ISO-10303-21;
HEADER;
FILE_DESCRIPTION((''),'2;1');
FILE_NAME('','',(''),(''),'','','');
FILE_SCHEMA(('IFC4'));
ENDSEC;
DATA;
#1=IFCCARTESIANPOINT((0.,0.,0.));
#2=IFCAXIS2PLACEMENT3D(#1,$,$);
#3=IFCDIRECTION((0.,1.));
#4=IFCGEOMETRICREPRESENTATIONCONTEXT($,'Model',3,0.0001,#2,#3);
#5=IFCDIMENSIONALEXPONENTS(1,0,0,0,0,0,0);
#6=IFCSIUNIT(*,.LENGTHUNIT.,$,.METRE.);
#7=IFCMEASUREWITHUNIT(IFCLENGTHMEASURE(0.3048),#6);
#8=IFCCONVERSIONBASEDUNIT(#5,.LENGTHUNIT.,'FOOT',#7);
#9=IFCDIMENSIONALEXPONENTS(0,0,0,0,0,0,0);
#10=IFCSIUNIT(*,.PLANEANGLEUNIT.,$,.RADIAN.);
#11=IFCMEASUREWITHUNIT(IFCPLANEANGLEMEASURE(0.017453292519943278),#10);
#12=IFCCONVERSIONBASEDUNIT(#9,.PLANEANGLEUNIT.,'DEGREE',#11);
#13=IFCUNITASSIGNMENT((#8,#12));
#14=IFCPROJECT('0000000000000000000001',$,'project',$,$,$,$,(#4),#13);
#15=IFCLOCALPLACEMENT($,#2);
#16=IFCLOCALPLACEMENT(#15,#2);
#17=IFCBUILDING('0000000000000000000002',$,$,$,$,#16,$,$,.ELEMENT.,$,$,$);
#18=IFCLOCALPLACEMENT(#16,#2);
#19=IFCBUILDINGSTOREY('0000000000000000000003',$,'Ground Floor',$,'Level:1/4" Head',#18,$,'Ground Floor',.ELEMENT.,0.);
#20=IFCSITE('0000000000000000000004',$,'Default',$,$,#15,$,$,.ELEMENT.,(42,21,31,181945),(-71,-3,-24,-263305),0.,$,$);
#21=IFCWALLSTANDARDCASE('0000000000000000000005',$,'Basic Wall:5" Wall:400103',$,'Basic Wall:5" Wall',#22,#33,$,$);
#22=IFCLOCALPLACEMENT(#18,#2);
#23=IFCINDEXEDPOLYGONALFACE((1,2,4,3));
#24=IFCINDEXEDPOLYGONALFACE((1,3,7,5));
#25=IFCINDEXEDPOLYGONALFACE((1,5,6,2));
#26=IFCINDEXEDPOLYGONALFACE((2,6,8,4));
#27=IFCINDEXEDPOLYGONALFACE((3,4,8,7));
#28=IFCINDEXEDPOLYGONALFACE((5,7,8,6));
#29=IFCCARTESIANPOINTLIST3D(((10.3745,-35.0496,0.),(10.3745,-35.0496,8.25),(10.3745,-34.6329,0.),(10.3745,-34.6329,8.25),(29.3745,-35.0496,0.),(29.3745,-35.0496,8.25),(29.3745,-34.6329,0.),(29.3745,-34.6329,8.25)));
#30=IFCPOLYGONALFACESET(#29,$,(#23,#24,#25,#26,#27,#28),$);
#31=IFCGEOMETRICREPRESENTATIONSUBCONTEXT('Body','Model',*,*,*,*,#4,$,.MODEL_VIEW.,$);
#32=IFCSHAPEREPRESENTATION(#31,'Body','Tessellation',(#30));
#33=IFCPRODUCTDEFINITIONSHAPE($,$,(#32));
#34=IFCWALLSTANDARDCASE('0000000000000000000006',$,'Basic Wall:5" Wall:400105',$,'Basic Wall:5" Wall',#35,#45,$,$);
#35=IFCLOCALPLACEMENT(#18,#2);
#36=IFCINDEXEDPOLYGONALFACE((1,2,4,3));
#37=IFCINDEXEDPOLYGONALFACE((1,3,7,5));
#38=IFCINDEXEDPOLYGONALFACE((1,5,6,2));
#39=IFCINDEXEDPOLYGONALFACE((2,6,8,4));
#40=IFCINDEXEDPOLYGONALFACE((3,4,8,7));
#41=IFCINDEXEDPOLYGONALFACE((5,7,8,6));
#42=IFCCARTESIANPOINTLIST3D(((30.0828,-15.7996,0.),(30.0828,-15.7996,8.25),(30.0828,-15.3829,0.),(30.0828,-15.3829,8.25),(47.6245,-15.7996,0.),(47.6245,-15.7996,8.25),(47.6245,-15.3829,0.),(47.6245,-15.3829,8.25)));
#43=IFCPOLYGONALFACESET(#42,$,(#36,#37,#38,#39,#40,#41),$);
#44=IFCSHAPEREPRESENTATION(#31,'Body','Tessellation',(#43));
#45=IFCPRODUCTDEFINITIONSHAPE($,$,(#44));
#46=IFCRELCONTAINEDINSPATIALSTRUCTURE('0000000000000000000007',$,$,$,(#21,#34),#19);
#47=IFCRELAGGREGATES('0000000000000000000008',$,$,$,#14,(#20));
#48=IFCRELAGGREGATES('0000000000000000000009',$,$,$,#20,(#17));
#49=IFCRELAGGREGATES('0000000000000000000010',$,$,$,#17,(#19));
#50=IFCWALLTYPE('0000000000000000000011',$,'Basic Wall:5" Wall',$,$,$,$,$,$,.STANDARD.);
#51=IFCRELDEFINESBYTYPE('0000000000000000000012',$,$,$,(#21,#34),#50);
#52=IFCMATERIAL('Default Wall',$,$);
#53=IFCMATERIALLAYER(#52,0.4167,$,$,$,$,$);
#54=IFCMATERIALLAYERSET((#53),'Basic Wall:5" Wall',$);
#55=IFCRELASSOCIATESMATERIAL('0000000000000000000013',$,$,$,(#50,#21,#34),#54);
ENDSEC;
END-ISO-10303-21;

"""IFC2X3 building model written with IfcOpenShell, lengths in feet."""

from ifc_helpers import new_model, entity, si_unit, converted_unit, direction, frame, frame_2d, origin, place, context, subcontext, project, spatial, rectangle, extrude, material, layer, layer_set, layer_usage, type_object, element, save


model = new_model("IFC2X3")

# Units and contexts
model_context = context("Model", 3, precision=0.0001, world=origin(), true_north=direction((0.0, 1.0)))
body_context = subcontext(model_context, "Body", "Model", "MODEL_VIEW")
ifc_project = project(units=[converted_unit("LENGTHUNIT", "FOOT", entity("IfcLengthMeasure", 0.3048), si_unit("LENGTHUNIT", "METRE"), dimensions=[1, 0, 0, 0, 0, 0, 0]), converted_unit("PLANEANGLEUNIT", "DEGREE", entity("IfcPlaneAngleMeasure", 0.017453292519943278), si_unit("PLANEANGLEUNIT", "RADIAN"), dimensions=[0, 0, 0, 0, 0, 0, 0])], contexts=[model_context])

# Site, building, storey
site_placement = place(None, origin())
site = spatial("IfcSite", under=ifc_project, at=site_placement, Name="Default", CompositionType="ELEMENT", RefLatitude=(42, 21, 31, 181945), RefLongitude=(-71, -3, -24, -263305), RefElevation=0.0)
building_placement = place(site_placement, origin())
building = spatial("IfcBuilding", under=site, at=building_placement, CompositionType="ELEMENT")
storey_placement = place(building_placement, origin())
storey = spatial("IfcBuildingStorey", under=building, at=storey_placement, Name="Ground Floor", ObjectType="Level:1/4\" Head", LongName="Ground Floor", CompositionType="ELEMENT", Elevation=0.0)

# Shared definitions
ifc_material_1 = material(Name="Default Wall")

# Wall
ifc_layer_1 = layer(ifc_material_1, 0.4167)
ifc_layer_set_1 = layer_set([ifc_layer_1], Name="Basic Wall:5\" Wall")
ifc_layer_usage_1 = layer_usage(ifc_layer_set_1, "AXIS2", "NEGATIVE", 0.2083)
wall_type_1 = type_object("IfcWallType", Name="Basic Wall:5\" Wall", PredefinedType="STANDARD", material=ifc_layer_set_1)
wall_1_placement = place(storey_placement, frame((29.3745, -34.8412, 0.0), z_axis=(0.0, 0.0, 1.0), x_axis=(-1.0, 0.0, 0.0)))
element("IfcWallStandardCase", 1, at=wall_1_placement, inside=storey, type_object=wall_type_1, material=ifc_layer_usage_1, Name="Basic Wall:5\" Wall:400103", ObjectType="Basic Wall:5\" Wall", context=body_context, shape_type="SweptSolid", body=[
    extrude(rectangle(XDim=19.0, YDim=0.4167, at=frame_2d((9.5, 0.0), x_axis=(-1.0, 0.0))), origin(), (0.0, 0.0, 1.0), 8.25),
])

# Wall
wall_2_placement = place(storey_placement, frame((30.0828, -15.5912, 0.0)))
element("IfcWallStandardCase", 2, at=wall_2_placement, inside=storey, type_object=wall_type_1, material=ifc_layer_usage_1, Name="Basic Wall:5\" Wall:400105", ObjectType="Basic Wall:5\" Wall", context=body_context, shape_type="SweptSolid", body=[
    extrude(rectangle(XDim=17.5417, YDim=0.4167, at=frame_2d((8.7708, 0.0), x_axis=(-1.0, 0.0))), origin(), (0.0, 0.0, 1.0), 8.25),
])

save(model, "model.ifc")
